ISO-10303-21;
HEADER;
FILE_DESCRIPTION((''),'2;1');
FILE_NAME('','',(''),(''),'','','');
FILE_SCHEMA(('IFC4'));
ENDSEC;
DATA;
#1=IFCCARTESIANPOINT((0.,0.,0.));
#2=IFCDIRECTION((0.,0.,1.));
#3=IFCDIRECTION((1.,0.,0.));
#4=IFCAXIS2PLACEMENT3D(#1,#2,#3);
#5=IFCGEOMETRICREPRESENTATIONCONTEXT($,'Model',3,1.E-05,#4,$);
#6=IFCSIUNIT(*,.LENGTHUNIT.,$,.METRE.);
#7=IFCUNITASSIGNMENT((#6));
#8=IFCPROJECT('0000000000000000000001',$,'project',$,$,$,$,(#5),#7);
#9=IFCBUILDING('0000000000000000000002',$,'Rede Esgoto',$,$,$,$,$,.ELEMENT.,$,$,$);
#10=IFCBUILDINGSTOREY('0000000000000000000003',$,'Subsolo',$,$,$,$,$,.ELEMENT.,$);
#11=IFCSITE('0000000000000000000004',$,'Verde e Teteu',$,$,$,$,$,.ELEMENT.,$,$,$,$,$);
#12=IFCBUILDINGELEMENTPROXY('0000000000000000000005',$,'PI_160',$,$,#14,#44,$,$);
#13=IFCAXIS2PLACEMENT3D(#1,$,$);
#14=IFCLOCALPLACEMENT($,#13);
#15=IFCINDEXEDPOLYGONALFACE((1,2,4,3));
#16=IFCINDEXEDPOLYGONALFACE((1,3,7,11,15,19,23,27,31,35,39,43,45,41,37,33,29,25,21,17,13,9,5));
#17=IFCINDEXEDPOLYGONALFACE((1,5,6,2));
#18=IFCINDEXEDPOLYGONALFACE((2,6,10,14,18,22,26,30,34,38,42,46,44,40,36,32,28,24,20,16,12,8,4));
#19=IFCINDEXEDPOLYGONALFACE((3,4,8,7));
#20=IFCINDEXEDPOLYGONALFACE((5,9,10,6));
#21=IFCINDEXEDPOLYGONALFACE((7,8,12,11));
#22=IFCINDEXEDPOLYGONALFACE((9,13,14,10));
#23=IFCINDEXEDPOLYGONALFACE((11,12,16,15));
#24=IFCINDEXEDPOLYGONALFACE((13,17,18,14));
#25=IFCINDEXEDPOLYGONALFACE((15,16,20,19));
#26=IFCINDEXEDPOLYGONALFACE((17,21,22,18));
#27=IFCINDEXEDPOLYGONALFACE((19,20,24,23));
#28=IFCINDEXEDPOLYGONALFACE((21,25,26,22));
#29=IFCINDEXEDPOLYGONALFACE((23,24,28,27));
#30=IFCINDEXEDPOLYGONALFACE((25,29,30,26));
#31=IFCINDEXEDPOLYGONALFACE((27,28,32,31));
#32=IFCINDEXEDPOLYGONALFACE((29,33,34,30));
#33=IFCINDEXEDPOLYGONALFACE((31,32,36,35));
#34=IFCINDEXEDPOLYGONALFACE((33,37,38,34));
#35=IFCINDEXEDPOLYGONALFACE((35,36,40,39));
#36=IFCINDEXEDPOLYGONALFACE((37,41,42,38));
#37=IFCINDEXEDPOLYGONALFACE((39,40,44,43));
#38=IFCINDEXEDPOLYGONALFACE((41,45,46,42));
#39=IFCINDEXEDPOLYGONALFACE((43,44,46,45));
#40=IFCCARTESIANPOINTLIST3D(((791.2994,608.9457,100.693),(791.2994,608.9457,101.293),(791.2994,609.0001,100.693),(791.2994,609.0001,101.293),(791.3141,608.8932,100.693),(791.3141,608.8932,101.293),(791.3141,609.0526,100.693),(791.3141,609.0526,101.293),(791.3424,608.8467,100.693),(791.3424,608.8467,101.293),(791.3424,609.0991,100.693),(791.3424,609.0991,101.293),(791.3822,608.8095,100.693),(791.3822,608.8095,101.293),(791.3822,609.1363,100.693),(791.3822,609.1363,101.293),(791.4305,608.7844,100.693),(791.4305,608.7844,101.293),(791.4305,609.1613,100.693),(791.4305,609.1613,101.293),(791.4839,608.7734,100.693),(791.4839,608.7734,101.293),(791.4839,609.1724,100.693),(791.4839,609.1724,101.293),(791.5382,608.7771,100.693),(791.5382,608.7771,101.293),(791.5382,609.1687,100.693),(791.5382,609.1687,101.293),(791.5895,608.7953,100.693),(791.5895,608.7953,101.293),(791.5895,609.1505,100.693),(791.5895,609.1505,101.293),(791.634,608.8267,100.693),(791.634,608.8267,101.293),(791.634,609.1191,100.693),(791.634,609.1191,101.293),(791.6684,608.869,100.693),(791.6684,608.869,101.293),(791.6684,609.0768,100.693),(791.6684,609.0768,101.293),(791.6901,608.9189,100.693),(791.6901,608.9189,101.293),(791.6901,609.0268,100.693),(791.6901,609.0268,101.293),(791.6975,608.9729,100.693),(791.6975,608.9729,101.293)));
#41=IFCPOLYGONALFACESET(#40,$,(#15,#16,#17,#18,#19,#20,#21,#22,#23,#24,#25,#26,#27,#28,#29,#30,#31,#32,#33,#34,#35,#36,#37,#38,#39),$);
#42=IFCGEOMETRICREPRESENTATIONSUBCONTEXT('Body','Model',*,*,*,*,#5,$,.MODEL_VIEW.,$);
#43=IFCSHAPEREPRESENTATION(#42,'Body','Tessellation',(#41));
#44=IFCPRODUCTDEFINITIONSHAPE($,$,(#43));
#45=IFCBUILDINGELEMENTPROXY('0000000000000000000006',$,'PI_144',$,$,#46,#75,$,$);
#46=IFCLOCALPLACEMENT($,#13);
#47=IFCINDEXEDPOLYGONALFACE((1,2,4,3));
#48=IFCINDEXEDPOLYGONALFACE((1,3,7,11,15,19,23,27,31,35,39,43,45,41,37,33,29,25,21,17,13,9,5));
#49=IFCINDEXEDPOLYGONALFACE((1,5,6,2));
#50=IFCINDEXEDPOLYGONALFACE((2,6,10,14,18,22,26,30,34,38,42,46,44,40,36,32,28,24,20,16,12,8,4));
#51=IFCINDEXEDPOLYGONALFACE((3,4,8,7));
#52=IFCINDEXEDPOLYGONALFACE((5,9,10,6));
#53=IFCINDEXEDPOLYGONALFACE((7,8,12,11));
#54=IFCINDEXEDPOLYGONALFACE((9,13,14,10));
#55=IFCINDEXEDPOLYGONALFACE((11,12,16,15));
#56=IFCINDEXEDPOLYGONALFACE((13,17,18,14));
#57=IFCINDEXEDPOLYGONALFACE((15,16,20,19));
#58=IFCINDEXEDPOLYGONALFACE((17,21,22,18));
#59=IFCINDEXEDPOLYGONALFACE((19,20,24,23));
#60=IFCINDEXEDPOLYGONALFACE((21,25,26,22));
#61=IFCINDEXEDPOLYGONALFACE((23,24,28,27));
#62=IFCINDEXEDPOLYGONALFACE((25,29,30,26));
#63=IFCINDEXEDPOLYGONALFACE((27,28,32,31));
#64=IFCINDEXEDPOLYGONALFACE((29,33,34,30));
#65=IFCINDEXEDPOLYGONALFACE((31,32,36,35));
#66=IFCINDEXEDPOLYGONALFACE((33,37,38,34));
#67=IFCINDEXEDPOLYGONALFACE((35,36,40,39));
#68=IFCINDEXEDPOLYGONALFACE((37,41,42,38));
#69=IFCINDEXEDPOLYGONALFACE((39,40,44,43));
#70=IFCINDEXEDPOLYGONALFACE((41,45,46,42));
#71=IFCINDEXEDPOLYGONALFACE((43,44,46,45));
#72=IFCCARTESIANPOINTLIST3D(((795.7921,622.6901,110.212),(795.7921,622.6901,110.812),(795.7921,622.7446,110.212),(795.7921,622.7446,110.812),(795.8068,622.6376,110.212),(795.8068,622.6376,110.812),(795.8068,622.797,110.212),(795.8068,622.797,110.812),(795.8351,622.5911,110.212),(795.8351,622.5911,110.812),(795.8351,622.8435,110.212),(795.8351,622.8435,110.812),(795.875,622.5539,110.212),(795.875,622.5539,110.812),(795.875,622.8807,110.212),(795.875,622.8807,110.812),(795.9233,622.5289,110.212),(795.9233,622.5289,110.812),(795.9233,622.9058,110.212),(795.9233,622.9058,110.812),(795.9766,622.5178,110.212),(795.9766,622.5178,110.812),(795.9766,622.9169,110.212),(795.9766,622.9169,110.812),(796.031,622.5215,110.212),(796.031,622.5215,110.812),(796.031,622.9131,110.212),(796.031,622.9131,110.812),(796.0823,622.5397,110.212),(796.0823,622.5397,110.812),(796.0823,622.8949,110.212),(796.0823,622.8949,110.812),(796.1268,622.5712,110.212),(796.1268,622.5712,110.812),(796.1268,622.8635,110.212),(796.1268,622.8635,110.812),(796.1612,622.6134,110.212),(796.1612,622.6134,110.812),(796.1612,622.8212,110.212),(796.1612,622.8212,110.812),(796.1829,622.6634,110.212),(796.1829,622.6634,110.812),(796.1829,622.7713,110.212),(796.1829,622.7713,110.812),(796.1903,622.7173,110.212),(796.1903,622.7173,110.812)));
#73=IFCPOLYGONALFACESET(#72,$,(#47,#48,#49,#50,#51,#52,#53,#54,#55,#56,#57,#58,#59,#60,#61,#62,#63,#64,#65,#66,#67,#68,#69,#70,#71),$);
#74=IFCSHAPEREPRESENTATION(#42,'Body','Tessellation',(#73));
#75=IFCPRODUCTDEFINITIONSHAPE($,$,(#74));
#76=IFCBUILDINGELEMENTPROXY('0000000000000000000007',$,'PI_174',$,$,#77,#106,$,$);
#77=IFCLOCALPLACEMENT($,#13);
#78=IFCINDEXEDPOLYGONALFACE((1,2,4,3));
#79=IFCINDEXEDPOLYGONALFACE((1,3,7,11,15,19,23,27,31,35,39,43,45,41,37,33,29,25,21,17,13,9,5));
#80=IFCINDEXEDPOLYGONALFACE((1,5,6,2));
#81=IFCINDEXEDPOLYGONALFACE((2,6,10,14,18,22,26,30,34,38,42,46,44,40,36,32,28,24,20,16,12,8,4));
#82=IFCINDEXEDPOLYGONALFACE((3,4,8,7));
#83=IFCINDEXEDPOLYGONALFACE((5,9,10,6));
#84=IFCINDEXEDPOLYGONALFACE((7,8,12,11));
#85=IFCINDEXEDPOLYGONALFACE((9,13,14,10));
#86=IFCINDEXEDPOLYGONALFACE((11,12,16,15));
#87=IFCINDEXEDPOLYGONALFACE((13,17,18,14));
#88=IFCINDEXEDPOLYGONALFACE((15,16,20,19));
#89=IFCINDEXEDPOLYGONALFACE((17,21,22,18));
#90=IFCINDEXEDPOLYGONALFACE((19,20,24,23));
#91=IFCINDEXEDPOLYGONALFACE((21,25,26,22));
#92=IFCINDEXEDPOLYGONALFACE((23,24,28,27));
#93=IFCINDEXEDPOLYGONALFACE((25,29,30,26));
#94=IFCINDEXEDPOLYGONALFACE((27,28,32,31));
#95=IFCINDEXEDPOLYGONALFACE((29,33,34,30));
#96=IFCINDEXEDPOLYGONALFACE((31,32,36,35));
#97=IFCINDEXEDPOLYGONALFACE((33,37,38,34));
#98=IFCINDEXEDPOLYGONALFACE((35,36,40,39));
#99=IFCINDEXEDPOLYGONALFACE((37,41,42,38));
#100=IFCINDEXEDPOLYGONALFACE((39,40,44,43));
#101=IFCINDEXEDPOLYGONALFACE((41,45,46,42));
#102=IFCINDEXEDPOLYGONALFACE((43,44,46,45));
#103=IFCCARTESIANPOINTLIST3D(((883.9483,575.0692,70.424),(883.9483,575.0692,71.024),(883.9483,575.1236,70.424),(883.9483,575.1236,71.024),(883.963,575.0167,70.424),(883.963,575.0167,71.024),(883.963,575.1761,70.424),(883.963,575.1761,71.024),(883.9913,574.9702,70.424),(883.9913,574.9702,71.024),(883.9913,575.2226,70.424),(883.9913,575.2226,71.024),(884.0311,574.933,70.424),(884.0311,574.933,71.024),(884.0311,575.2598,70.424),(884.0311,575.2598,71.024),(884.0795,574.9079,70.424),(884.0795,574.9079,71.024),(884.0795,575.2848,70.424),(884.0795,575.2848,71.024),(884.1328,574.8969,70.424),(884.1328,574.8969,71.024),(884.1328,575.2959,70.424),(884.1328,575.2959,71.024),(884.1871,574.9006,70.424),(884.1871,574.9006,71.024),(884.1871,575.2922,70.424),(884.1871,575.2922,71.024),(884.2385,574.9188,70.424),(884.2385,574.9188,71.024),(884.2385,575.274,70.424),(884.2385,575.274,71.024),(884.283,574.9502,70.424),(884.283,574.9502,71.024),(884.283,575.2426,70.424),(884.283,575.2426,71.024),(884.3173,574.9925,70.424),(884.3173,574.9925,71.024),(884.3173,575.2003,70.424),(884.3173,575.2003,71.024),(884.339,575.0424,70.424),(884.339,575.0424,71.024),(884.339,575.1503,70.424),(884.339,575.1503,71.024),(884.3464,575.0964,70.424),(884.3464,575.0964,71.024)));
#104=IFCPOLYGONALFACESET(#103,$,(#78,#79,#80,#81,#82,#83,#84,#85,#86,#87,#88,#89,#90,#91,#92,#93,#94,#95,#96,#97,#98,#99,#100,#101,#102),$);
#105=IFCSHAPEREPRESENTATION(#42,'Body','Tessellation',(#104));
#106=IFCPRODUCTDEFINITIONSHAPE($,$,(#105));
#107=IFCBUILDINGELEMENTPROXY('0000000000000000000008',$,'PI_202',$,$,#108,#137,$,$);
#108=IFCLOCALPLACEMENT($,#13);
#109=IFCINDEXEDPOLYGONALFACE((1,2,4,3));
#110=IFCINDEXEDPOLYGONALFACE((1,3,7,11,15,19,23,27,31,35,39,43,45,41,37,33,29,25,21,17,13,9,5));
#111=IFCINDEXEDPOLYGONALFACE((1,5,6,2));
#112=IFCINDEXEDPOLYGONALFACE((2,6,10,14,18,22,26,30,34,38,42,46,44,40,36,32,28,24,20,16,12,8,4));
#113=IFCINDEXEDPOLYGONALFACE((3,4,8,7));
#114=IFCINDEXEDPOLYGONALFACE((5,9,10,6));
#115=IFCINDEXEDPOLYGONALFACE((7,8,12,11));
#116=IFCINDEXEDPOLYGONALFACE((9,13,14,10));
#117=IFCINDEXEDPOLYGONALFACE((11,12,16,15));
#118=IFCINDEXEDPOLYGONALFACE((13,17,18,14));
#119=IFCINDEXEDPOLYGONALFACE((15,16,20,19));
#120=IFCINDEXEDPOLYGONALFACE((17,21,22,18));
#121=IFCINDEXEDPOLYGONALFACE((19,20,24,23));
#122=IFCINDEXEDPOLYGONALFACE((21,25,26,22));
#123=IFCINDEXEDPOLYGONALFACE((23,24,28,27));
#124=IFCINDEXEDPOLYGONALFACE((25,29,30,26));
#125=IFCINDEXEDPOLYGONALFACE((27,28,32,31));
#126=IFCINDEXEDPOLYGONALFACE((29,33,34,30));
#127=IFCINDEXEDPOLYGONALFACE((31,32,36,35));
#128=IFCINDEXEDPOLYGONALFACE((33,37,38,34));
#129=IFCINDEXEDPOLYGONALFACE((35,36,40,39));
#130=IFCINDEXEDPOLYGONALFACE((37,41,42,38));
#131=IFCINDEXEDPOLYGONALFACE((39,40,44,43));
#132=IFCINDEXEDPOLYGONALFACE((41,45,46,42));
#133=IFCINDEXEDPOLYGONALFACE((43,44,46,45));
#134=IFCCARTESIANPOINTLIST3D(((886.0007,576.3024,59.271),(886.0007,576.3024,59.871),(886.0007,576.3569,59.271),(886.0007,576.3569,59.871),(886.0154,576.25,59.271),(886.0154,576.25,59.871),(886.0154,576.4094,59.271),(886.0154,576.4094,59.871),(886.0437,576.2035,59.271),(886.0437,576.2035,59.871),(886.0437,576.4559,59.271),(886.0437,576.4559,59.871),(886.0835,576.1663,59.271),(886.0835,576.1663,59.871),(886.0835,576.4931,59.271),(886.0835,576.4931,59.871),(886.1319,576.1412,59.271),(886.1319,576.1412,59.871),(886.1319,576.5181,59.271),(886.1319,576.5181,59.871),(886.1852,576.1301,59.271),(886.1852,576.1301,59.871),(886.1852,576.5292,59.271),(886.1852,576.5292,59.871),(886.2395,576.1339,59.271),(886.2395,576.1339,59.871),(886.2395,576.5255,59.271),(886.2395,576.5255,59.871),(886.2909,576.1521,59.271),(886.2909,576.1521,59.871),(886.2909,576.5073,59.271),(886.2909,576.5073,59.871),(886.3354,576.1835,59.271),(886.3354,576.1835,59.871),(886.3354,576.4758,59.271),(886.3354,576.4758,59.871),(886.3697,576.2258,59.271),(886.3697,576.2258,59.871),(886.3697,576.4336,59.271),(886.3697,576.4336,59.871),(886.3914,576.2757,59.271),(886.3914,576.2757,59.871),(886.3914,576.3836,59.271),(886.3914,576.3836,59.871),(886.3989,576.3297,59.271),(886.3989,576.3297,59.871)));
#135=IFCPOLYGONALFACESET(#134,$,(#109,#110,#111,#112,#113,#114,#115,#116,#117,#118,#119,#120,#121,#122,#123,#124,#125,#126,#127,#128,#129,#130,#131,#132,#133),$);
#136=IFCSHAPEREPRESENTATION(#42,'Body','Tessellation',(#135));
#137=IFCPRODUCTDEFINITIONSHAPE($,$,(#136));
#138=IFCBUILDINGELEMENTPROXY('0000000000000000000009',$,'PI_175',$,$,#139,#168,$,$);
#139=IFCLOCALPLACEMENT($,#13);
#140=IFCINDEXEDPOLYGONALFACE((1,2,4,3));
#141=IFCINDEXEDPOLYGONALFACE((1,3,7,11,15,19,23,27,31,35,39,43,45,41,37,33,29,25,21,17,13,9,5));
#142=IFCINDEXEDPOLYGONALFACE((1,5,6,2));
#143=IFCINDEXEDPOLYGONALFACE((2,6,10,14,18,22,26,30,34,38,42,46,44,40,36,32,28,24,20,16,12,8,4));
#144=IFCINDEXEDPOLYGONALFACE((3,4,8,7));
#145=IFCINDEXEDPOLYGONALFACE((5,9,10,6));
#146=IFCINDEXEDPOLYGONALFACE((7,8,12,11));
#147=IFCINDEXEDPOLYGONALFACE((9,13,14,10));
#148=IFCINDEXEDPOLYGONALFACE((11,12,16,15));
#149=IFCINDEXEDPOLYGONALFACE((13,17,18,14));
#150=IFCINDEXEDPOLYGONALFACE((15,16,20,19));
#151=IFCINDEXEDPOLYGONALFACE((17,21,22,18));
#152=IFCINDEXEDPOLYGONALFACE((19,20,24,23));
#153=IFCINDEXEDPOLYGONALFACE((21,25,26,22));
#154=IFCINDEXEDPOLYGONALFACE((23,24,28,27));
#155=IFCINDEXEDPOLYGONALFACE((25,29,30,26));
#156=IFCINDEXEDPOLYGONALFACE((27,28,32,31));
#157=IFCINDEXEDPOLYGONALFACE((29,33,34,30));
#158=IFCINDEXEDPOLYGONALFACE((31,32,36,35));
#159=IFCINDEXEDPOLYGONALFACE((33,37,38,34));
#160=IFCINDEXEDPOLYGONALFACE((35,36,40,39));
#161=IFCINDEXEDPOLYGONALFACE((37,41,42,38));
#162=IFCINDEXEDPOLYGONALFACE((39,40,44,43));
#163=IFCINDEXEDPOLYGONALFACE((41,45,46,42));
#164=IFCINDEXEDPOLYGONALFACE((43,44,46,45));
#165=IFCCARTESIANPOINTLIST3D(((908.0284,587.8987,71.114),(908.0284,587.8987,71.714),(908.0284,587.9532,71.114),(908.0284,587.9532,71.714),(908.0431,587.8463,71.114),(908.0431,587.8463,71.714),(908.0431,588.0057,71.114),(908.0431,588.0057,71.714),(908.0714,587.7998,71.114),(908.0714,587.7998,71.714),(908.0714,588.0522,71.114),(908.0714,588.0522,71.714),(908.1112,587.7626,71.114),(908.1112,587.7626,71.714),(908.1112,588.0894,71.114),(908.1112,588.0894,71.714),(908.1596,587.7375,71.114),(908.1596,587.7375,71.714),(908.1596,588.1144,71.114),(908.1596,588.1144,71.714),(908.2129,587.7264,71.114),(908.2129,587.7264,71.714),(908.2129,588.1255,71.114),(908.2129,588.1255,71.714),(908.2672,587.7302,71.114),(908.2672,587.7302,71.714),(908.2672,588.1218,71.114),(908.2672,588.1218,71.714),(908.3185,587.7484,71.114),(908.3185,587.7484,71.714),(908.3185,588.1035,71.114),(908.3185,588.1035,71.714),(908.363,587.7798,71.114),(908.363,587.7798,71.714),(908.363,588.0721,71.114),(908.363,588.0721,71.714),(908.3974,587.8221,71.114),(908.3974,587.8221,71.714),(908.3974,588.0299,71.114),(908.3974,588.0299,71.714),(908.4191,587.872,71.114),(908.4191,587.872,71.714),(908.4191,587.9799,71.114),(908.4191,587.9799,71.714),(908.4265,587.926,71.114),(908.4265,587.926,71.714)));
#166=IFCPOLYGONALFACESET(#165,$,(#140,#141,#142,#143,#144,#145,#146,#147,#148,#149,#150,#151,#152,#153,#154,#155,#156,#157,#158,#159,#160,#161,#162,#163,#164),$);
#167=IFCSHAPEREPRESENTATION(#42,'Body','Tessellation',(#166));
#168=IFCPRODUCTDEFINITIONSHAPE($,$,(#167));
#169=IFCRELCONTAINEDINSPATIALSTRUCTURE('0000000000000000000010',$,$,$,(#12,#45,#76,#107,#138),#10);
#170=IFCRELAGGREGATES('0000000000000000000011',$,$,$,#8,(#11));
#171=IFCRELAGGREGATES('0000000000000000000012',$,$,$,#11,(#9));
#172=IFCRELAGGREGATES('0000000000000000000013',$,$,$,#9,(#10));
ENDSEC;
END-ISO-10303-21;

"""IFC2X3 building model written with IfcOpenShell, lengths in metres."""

from ifc_helpers import new_model, si_unit, frame, origin_with_axes, origin_2d, place, context, subcontext, project, spatial, circle, extrude, element, save


model = new_model("IFC2X3")

# Units and contexts
model_context = context("Model", 3, precision=1e-05, world=origin_with_axes())
body_context = subcontext(model_context, "Body", "Model", "MODEL_VIEW")
ifc_project = project(units=[si_unit("LENGTHUNIT", "METRE")], contexts=[model_context])

# Site, building, storey
site = spatial("IfcSite", under=ifc_project, Name="Verde e Teteu", CompositionType="ELEMENT")
building = spatial("IfcBuilding", under=site, Name="Rede Esgoto", CompositionType="ELEMENT")
storey = spatial("IfcBuildingStorey", under=building, Name="Subsolo", CompositionType="ELEMENT")

# Building element proxies
proxy_1_placement = place(None, frame((791.4975, 608.9729, 100.693), z_axis=(0.0, 0.0, 1.0), x_axis=(1.0, 0.0, 0.0)))
element("IfcBuildingElementProxy", 1, at=proxy_1_placement, inside=storey, Name="PI_160", context=body_context, shape_type="SweptSolid", body=[
    extrude(circle(Radius=0.2, at=origin_2d()), origin_with_axes(), (0.0, 0.0, 1.0), 0.6),
])
for number, where, z_axis, x_axis, name in (
    (2, (795.9903, 622.7173, 110.212), (0.0, 0.0, 1.0), (1.0, 0.0, 0.0), "PI_144"),
    (3, (884.1464, 575.0964, 70.424), (0.0, 0.0, 1.0), (1.0, 0.0, 0.0), "PI_174"),
):
    element("IfcBuildingElementProxy", number, at=place(None, frame(where, z_axis=z_axis, x_axis=x_axis)), inside=storey, Name=name, context=body_context, shape_type="SweptSolid", body=[
        extrude(circle(Radius=0.2, at=origin_2d()), origin_with_axes(), (0.0, 0.0, 1.0), 0.6),
    ])
proxy_2_placement = place(None, frame((886.1989, 576.3297, 59.271), z_axis=(0.0, 0.0, 1.0), x_axis=(1.0, 0.0, 0.0)))
element("IfcBuildingElementProxy", 4, at=proxy_2_placement, inside=storey, Name="PI_202", context=body_context, shape_type="SweptSolid", body=[
    extrude(circle(Radius=0.2, at=origin_2d()), origin_with_axes(), (0.0, 0.0, 1.0), 0.6),
])
proxy_3_placement = place(None, frame((908.2265, 587.926, 71.114), z_axis=(0.0, 0.0, 1.0), x_axis=(1.0, 0.0, 0.0)))
element("IfcBuildingElementProxy", 5, at=proxy_3_placement, inside=storey, Name="PI_175", context=body_context, shape_type="SweptSolid", body=[
    extrude(circle(Radius=0.2, at=origin_2d()), origin_with_axes(), (0.0, 0.0, 1.0), 0.6),
])

save(model, "model.ifc")
